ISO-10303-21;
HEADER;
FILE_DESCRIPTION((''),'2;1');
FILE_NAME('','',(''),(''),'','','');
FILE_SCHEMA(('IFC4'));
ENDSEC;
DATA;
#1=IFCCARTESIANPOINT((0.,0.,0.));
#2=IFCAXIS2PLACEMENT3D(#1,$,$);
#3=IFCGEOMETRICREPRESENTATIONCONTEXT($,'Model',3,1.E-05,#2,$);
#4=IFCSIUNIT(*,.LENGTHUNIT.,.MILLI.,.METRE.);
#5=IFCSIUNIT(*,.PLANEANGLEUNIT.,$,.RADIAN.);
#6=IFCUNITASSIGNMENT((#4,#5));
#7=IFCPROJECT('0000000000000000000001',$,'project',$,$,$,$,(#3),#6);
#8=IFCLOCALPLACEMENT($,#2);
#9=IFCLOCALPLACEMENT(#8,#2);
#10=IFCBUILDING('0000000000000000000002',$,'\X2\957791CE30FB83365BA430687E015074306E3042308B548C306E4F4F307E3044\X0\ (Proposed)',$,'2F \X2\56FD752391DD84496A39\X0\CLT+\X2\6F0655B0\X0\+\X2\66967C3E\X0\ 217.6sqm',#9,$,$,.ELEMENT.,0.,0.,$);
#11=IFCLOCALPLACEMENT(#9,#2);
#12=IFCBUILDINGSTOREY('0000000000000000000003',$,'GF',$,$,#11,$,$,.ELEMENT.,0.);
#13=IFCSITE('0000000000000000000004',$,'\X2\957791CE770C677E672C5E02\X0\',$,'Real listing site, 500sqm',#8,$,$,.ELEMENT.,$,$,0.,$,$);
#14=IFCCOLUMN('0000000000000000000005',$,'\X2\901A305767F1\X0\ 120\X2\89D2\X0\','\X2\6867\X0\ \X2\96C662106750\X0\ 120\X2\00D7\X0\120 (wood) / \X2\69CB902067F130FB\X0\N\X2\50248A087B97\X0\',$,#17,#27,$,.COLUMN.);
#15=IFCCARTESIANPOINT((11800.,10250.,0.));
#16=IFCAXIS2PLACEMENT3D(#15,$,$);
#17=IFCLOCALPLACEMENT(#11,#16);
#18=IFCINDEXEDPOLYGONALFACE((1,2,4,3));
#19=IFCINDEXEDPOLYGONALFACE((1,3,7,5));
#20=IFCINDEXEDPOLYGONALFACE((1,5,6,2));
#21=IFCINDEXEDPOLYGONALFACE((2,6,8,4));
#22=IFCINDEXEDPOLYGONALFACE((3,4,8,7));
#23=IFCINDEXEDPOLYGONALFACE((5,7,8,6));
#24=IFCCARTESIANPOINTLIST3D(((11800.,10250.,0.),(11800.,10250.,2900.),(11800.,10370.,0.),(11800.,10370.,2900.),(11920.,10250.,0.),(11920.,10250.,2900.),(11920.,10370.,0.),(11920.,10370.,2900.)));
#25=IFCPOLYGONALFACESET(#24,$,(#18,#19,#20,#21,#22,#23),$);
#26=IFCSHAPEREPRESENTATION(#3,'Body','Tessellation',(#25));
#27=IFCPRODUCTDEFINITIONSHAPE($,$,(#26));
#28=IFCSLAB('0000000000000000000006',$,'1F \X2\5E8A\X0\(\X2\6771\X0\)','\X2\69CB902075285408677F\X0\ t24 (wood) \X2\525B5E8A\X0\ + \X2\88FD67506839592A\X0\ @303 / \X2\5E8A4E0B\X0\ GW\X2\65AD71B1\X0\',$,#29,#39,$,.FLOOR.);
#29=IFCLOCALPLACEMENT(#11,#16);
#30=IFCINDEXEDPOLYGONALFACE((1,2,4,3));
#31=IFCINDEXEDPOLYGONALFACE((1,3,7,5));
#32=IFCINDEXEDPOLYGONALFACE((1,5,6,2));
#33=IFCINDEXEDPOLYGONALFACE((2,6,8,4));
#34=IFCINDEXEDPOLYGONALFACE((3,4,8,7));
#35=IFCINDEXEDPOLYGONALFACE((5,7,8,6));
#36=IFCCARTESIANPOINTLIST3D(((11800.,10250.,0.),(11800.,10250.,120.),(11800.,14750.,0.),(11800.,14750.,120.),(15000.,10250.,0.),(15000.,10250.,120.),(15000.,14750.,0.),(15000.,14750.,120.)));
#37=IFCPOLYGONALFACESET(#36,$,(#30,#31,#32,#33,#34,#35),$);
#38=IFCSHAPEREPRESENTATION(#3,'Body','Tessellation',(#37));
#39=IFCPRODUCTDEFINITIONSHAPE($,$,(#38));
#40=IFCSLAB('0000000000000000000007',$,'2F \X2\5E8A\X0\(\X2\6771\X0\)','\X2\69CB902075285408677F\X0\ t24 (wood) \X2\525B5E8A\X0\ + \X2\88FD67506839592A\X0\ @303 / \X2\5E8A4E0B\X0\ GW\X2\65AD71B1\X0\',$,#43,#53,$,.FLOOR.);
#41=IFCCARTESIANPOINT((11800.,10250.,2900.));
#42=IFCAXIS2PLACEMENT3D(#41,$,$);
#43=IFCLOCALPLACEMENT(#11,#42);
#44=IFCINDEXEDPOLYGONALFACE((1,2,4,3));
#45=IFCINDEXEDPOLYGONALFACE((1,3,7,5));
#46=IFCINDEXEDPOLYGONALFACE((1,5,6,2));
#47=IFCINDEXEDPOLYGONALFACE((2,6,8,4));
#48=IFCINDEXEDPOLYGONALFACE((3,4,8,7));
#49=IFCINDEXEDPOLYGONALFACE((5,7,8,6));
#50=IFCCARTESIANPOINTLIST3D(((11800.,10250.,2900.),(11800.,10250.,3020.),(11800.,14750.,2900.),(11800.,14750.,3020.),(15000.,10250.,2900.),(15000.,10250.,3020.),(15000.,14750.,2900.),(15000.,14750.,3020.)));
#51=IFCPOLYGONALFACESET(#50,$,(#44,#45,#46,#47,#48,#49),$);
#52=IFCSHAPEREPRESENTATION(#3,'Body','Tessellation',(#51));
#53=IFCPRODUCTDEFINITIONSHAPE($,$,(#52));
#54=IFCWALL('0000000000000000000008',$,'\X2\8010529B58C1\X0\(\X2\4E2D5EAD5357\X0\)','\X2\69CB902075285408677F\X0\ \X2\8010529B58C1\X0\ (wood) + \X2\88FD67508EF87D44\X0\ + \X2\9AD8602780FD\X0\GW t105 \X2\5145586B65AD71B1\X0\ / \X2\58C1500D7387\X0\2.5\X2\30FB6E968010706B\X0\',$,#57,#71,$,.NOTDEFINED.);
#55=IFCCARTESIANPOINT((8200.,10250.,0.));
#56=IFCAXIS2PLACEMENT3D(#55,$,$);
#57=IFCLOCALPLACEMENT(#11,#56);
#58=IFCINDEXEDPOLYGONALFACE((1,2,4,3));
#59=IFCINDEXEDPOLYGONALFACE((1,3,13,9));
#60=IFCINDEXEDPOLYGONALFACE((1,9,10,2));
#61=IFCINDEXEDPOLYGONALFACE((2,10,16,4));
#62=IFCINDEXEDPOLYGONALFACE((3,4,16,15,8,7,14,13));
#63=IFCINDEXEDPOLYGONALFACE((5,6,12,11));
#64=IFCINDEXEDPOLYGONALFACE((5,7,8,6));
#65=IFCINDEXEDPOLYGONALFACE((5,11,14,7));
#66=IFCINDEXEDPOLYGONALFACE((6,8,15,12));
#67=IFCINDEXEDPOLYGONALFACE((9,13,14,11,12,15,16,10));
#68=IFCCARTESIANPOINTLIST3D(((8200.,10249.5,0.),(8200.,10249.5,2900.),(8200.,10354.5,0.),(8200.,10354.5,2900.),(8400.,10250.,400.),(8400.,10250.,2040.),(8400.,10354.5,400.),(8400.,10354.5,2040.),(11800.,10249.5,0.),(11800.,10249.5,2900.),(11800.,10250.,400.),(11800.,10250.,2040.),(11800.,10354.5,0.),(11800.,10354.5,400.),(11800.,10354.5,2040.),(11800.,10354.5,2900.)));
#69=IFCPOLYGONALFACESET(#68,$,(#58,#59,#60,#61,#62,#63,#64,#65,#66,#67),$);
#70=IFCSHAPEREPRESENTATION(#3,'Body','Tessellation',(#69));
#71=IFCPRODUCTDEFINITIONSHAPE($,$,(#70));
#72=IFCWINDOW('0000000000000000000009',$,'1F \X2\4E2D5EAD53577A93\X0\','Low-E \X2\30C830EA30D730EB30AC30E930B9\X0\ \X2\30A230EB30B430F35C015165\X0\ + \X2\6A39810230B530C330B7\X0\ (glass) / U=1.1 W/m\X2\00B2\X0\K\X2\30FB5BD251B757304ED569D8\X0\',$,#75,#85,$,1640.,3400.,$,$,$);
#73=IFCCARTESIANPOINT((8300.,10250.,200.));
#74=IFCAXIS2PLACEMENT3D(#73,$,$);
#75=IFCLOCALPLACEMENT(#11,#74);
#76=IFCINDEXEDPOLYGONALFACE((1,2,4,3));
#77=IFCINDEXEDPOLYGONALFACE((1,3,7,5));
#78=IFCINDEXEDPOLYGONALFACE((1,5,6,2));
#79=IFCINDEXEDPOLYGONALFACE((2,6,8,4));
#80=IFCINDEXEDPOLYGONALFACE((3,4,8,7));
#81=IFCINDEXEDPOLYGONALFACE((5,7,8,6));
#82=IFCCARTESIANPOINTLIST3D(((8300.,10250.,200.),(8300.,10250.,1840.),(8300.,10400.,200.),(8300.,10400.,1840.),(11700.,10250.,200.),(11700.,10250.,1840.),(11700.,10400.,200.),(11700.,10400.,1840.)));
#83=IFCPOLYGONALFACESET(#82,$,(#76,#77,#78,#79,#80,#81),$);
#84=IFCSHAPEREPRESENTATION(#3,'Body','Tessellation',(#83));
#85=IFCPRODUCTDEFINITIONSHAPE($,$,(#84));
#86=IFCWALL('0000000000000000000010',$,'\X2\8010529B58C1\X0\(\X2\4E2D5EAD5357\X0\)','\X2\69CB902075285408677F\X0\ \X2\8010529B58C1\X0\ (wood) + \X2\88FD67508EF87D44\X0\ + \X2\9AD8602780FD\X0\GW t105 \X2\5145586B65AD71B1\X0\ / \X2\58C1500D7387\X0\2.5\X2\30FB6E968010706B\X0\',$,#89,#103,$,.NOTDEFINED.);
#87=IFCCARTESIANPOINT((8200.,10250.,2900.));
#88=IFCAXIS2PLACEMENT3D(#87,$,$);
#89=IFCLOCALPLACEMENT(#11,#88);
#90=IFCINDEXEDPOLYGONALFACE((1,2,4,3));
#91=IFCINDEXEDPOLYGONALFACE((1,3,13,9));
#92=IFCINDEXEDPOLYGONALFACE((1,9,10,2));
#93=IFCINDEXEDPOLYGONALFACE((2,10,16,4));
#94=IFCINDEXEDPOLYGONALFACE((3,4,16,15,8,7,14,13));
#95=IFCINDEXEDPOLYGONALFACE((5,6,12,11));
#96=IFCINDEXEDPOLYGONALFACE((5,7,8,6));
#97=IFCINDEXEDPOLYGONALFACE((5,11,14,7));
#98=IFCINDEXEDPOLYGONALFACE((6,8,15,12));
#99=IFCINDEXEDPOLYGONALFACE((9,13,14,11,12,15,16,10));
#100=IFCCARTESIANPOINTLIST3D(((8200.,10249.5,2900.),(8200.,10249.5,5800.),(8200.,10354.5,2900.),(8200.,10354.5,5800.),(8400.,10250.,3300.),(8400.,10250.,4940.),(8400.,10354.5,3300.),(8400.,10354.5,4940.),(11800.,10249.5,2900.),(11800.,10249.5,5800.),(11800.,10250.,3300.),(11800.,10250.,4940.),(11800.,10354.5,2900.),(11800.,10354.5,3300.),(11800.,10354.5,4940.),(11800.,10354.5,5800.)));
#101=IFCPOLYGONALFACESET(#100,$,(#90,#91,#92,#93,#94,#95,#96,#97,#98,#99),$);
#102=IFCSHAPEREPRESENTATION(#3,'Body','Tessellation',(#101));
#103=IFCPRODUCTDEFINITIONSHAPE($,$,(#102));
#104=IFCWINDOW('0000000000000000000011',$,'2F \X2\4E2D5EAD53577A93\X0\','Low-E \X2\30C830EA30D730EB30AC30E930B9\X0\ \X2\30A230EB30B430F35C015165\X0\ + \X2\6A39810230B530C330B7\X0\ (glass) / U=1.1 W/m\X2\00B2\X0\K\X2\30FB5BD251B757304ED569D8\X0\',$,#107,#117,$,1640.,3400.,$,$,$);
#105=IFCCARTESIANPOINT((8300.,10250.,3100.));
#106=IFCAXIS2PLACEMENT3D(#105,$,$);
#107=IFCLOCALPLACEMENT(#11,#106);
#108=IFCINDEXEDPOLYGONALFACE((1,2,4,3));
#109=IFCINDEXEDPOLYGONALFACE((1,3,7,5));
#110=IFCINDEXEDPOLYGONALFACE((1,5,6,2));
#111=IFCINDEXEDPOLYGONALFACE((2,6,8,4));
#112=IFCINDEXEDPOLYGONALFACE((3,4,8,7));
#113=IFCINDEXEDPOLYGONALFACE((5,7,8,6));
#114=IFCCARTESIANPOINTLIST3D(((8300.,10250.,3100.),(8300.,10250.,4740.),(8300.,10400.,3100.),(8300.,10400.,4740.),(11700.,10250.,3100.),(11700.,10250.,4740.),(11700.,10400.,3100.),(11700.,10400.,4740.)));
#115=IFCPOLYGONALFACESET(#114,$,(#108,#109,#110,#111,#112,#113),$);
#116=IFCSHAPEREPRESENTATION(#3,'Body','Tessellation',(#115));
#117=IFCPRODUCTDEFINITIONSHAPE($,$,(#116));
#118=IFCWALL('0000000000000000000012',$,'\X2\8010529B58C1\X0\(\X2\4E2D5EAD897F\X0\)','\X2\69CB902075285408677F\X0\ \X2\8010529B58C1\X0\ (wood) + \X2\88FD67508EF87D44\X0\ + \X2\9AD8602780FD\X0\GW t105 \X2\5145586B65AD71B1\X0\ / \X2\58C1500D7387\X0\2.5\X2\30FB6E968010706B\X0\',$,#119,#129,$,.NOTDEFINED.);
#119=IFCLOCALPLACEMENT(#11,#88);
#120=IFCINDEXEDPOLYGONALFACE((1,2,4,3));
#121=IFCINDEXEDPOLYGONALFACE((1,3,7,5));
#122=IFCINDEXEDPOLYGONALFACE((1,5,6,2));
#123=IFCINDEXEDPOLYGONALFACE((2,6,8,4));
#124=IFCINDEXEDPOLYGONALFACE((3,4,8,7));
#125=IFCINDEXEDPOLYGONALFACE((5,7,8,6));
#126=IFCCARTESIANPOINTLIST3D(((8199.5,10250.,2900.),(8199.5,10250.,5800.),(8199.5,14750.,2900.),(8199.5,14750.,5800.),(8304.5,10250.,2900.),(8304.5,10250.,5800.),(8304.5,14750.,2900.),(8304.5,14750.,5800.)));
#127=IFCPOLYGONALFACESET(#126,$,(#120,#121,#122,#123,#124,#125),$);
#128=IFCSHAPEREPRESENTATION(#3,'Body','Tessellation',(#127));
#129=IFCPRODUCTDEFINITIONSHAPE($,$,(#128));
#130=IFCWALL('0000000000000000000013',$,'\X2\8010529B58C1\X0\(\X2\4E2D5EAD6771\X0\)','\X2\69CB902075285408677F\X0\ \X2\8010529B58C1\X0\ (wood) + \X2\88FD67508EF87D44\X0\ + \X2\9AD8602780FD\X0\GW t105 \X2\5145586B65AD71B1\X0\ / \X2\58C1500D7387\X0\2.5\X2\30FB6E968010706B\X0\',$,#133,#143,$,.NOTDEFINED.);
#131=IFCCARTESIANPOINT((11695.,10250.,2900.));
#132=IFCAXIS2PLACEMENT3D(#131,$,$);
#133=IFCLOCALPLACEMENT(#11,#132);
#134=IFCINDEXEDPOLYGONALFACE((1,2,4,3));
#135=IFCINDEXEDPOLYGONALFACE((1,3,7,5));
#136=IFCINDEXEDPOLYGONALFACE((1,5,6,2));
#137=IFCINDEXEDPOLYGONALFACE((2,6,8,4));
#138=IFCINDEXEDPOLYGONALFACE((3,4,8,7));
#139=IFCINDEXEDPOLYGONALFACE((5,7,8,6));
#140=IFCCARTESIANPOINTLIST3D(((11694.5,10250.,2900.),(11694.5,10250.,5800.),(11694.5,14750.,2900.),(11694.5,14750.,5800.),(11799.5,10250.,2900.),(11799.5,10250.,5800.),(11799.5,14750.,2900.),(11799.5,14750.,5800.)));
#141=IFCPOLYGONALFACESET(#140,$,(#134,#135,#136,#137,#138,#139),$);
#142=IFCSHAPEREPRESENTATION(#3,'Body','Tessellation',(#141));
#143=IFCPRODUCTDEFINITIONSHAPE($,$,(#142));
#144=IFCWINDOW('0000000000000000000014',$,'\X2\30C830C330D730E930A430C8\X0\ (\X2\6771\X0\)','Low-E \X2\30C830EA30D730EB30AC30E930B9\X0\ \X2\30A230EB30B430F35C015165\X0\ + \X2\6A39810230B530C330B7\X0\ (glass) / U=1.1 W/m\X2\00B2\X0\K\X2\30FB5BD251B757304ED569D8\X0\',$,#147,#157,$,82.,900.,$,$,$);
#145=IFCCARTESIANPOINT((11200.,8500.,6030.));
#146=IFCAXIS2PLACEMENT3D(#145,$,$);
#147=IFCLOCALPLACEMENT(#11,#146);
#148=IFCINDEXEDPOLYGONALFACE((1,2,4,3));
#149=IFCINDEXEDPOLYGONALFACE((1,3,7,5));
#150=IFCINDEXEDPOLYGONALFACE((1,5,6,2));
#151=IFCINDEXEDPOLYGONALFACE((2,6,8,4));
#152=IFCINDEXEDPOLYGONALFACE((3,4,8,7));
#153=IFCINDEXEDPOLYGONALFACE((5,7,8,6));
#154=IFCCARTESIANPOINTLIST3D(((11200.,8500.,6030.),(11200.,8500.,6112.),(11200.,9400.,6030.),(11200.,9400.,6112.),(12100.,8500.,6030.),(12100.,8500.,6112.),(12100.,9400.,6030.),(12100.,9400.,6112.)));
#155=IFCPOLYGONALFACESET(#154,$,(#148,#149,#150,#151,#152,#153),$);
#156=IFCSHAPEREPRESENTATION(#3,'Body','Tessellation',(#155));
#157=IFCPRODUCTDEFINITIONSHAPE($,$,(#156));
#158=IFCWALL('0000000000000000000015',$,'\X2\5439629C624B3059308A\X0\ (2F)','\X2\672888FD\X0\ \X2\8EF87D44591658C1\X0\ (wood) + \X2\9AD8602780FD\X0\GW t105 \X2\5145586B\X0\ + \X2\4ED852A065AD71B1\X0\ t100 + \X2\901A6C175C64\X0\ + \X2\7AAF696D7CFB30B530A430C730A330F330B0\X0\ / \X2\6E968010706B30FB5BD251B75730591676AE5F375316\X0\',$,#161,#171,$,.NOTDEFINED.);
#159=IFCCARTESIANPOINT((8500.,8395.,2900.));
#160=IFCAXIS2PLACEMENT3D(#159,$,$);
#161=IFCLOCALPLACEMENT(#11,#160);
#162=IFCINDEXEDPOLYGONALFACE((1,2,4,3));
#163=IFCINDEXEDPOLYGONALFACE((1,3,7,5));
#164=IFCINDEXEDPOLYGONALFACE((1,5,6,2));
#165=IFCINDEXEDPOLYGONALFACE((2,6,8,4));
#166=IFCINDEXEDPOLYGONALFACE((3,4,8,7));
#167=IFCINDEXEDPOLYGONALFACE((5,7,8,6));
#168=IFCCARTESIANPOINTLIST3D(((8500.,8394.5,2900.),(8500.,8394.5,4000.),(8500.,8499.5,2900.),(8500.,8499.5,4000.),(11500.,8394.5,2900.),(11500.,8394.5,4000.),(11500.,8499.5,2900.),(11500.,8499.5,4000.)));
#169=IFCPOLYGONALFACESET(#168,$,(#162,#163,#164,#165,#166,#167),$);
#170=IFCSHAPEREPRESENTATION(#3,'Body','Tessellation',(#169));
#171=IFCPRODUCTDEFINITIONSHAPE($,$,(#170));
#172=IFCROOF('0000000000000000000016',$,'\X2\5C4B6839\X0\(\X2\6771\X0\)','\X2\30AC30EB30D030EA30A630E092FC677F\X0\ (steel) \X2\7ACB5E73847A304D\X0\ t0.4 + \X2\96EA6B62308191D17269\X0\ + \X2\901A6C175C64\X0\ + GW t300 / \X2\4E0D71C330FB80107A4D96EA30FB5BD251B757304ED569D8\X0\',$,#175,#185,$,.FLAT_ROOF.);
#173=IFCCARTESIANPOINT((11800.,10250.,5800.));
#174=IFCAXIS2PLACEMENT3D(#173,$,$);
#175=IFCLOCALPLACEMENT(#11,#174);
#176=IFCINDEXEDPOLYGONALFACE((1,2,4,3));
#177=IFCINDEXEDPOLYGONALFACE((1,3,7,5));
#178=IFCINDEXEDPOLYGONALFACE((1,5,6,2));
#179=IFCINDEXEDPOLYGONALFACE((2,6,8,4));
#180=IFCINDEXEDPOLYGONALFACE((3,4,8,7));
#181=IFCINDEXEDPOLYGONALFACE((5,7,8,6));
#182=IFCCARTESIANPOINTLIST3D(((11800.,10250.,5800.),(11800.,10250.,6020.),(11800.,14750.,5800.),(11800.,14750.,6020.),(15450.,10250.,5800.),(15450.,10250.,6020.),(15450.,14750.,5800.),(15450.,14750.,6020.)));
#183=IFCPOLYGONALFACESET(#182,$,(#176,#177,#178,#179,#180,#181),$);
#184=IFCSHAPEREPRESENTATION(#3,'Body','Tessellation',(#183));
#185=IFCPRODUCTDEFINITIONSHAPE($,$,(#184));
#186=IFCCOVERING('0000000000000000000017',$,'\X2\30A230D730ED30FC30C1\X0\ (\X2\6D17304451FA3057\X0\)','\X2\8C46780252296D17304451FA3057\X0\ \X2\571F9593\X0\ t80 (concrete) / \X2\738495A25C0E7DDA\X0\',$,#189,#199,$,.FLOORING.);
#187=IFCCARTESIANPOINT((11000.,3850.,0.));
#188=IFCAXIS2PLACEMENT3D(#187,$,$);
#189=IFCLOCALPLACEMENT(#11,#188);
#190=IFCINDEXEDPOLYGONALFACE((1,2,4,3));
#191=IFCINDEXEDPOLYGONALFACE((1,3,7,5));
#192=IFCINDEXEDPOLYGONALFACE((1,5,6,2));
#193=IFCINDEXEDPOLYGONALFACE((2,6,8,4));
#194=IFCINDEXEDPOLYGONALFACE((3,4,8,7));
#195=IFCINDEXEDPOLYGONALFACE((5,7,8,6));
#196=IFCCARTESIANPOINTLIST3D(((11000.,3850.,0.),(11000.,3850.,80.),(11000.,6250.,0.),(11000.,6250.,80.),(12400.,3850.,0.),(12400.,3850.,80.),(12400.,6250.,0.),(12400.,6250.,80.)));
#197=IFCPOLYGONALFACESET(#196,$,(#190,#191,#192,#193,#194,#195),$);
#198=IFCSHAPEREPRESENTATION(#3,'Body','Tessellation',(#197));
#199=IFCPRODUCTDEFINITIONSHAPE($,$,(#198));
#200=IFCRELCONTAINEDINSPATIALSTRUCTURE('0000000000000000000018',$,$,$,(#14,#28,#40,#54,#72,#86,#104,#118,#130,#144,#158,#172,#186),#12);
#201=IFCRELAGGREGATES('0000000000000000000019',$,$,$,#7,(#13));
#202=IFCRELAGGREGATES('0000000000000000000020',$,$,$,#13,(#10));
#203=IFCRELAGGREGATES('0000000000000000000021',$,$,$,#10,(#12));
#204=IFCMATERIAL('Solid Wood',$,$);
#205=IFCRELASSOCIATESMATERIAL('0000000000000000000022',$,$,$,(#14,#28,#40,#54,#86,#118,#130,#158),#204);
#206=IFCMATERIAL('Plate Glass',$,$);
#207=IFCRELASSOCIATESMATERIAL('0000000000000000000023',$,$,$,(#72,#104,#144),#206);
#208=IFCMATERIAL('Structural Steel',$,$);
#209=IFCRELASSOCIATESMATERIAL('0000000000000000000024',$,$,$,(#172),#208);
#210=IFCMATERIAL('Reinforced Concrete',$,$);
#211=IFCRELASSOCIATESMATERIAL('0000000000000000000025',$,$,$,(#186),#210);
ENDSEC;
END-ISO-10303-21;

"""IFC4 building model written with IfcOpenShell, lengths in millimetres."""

from ifc_helpers import new_model, si_unit, frame, frame_2d, origin, place, context, project, spatial, rectangle, extrude, material, element, fill, save


model = new_model("IFC4")

# Units and contexts
model_context = context("Model", 3, precision=1e-05, world=origin())
ifc_project = project(units=[si_unit("LENGTHUNIT", "METRE", prefix="MILLI"), si_unit("PLANEANGLEUNIT", "RADIAN")], contexts=[model_context])

# Site, building, storey
site_placement = place(None, origin())
site = spatial("IfcSite", under=ifc_project, at=site_placement, Name="長野県松本市", ObjectType="Real listing site, 500sqm", CompositionType="ELEMENT", RefElevation=0.0)
building_placement = place(site_placement, origin())
building = spatial("IfcBuilding", under=site, at=building_placement, Name="長野・茶室と縁側のある和の住まい (Proposed)", ObjectType="2F 国産針葉樹CLT+漆喰+暖簾 217.6sqm", CompositionType="ELEMENT", ElevationOfRefHeight=0.0, ElevationOfTerrain=0.0)
storey_placement = place(building_placement, origin())
storey = spatial("IfcBuildingStorey", under=building, at=storey_placement, Name="GF", CompositionType="ELEMENT", Elevation=0.0)

# Column
ifc_material_1 = material(Name="Solid Wood")
column_1_placement = place(storey_placement, frame((11800.0, 10250.0, 0.0)))
element("IfcColumn", 1, at=column_1_placement, inside=storey, material=ifc_material_1, Name="通し柱 120角", Description="桧 集成材 120×120 (wood) / 構造柱・N値計算", PredefinedType="COLUMN", context=model_context, shape_type="SweptSolid", body=[
    extrude(rectangle(XDim=120.0, YDim=120.0, at=frame_2d((60.0, 60.0))), frame((11800.0, 10250.0, 0.0)), (0.0, 0.0, 1.0), 2900.0),
])

# Slabs
slab_1_placement = place(storey_placement, frame((11800.0, 10250.0, 0.0)))
element("IfcSlab", 2, at=slab_1_placement, inside=storey, material=ifc_material_1, Name="1F 床(東)", Description="構造用合板 t24 (wood) 剛床 + 製材根太 @303 / 床下 GW断熱", PredefinedType="FLOOR", context=model_context, shape_type="SweptSolid", body=[
    extrude(rectangle(XDim=3200.0, YDim=4500.0, at=frame_2d((1600.0, 2250.0))), frame((11800.0, 10250.0, 0.0)), (0.0, 0.0, 1.0), 120.0),
])
slab_2_placement = place(storey_placement, frame((11800.0, 10250.0, 2900.0)))
element("IfcSlab", 3, at=slab_2_placement, inside=storey, material=ifc_material_1, Name="2F 床(東)", Description="構造用合板 t24 (wood) 剛床 + 製材根太 @303 / 床下 GW断熱", PredefinedType="FLOOR", context=model_context, shape_type="SweptSolid", body=[
    extrude(rectangle(XDim=3200.0, YDim=4500.0, at=frame_2d((1600.0, 2250.0))), frame((11800.0, 10250.0, 2900.0)), (0.0, 0.0, 1.0), 120.0),
])

# Wall, opening, window
wall_1_placement = place(storey_placement, frame((8200.0, 10250.0, 0.0)))
wall_1 = element("IfcWall", 4, at=wall_1_placement, inside=storey, material=ifc_material_1, Name="耐力壁(中庭南)", Description="構造用合板 耐力壁 (wood) + 製材軸組 + 高性能GW t105 充填断熱 / 壁倍率2.5・準耐火", PredefinedType="NOTDEFINED", context=model_context, shape_type="SweptSolid", body=[
    extrude(rectangle(XDim=3600.0, YDim=105.0, at=frame_2d((1800.0, 52.0))), frame((8200.0, 10250.0, 0.0)), (0.0, 0.0, 1.0), 2900.0),
])
opening_1_placement = place(storey_placement, frame((8300.0, 10250.0, 200.0)))
opening_1 = element("IfcOpeningElement", 5, at=opening_1_placement, cuts=wall_1, PredefinedType="NOTDEFINED", context=model_context, shape_type="SweptSolid", body=[
    extrude(rectangle(XDim=3400.0, YDim=150.0, at=frame_2d((1700.0, 75.0))), frame((8300.0, 10250.0, 200.0)), (0.0, 0.0, 1.0), 1640.0),
])
ifc_material_2 = material(Name="Plate Glass")
window_1_placement = place(storey_placement, frame((8300.0, 10250.0, 200.0)))
window_1 = element("IfcWindow", 6, at=window_1_placement, inside=storey, material=ifc_material_2, Name="1F 中庭南窓", Description="Low-E トリプルガラス アルゴン封入 + 樹脂サッシ (glass) / U=1.1 W/m²K・寒冷地仕様", OverallHeight=1640.0, OverallWidth=3400.0, context=model_context, shape_type="SweptSolid", body=[
    extrude(rectangle(XDim=3400.0, YDim=150.0, at=frame_2d((1700.0, 75.0))), frame((8300.0, 10250.0, 200.0)), (0.0, 0.0, 1.0), 1640.0),
])
fill(opening_1, window_1)

# Wall, opening, window
wall_2_placement = place(storey_placement, frame((8200.0, 10250.0, 2900.0)))
wall_2 = element("IfcWall", 7, at=wall_2_placement, inside=storey, material=ifc_material_1, Name="耐力壁(中庭南)", Description="構造用合板 耐力壁 (wood) + 製材軸組 + 高性能GW t105 充填断熱 / 壁倍率2.5・準耐火", PredefinedType="NOTDEFINED", context=model_context, shape_type="SweptSolid", body=[
    extrude(rectangle(XDim=3600.0, YDim=105.0, at=frame_2d((1800.0, 52.0))), frame((8200.0, 10250.0, 2900.0)), (0.0, 0.0, 1.0), 2900.0),
])
opening_2_placement = place(storey_placement, frame((8300.0, 10250.0, 3100.0)))
opening_2 = element("IfcOpeningElement", 8, at=opening_2_placement, cuts=wall_2, PredefinedType="NOTDEFINED", context=model_context, shape_type="SweptSolid", body=[
    extrude(rectangle(XDim=3400.0, YDim=150.0, at=frame_2d((1700.0, 75.0))), frame((8300.0, 10250.0, 3100.0)), (0.0, 0.0, 1.0), 1640.0),
])
window_2_placement = place(storey_placement, frame((8300.0, 10250.0, 3100.0)))
window_2 = element("IfcWindow", 9, at=window_2_placement, inside=storey, material=ifc_material_2, Name="2F 中庭南窓", Description="Low-E トリプルガラス アルゴン封入 + 樹脂サッシ (glass) / U=1.1 W/m²K・寒冷地仕様", OverallHeight=1640.0, OverallWidth=3400.0, context=model_context, shape_type="SweptSolid", body=[
    extrude(rectangle(XDim=3400.0, YDim=150.0, at=frame_2d((1700.0, 75.0))), frame((8300.0, 10250.0, 3100.0)), (0.0, 0.0, 1.0), 1640.0),
])
fill(opening_2, window_2)

# Walls
wall_3_placement = place(storey_placement, frame((8200.0, 10250.0, 2900.0)))
element("IfcWall", 10, at=wall_3_placement, inside=storey, material=ifc_material_1, Name="耐力壁(中庭西)", Description="構造用合板 耐力壁 (wood) + 製材軸組 + 高性能GW t105 充填断熱 / 壁倍率2.5・準耐火", PredefinedType="NOTDEFINED", context=model_context, shape_type="SweptSolid", body=[
    extrude(rectangle(XDim=105.0, YDim=4500.0, at=frame_2d((52.0, 2250.0))), frame((8200.0, 10250.0, 2900.0)), (0.0, 0.0, 1.0), 2900.0),
])
wall_4_placement = place(storey_placement, frame((11695.0, 10250.0, 2900.0)))
element("IfcWall", 11, at=wall_4_placement, inside=storey, material=ifc_material_1, Name="耐力壁(中庭東)", Description="構造用合板 耐力壁 (wood) + 製材軸組 + 高性能GW t105 充填断熱 / 壁倍率2.5・準耐火", PredefinedType="NOTDEFINED", context=model_context, shape_type="SweptSolid", body=[
    extrude(rectangle(XDim=105.0, YDim=4500.0, at=frame_2d((52.0, 2250.0))), frame((11695.0, 10250.0, 2900.0)), (0.0, 0.0, 1.0), 2900.0),
])

# Window
window_3_placement = place(storey_placement, frame((11200.0, 8500.0, 6030.0)))
element("IfcWindow", 12, at=window_3_placement, inside=storey, material=ifc_material_2, Name="トップライト (東)", Description="Low-E トリプルガラス アルゴン封入 + 樹脂サッシ (glass) / U=1.1 W/m²K・寒冷地仕様", OverallHeight=82.0, OverallWidth=900.0, context=model_context, shape_type="SweptSolid", body=[
    extrude(rectangle(XDim=900.0, YDim=900.0, at=frame_2d((450.0, 450.0))), frame((11200.0, 8500.0, 6030.0)), (0.0, 0.0, 1.0), 82.0),
])

# Wall
wall_5_placement = place(storey_placement, frame((8500.0, 8395.0, 2900.0)))
element("IfcWall", 13, at=wall_5_placement, inside=storey, material=ifc_material_1, Name="吹抜手すり (2F)", Description="木製 軸組外壁 (wood) + 高性能GW t105 充填 + 付加断熱 t100 + 通気層 + 窯業系サイディング / 準耐火・寒冷地外皮強化", PredefinedType="NOTDEFINED", context=model_context, shape_type="SweptSolid", body=[
    extrude(rectangle(XDim=3000.0, YDim=105.0, at=frame_2d((1500.0, 52.0))), frame((8500.0, 8395.0, 2900.0)), (0.0, 0.0, 1.0), 1100.0),
])

# Roof
ifc_material_3 = material(Name="Structural Steel")
for number, where, name in (
    (14, (11800.0, 10250.0, 5800.0), "屋根(東)"),
):
    element("IfcRoof", number, at=place(storey_placement, frame(where)), inside=storey, material=ifc_material_3, Name=name, Description="ガルバリウム鋼板 (steel) 立平葺き t0.4 + 雪止め金物 + 通気層 + GW t300 / 不燃・耐積雪・寒冷地仕様", PredefinedType="FLAT_ROOF", context=model_context, shape_type="SweptSolid", body=[
        extrude(rectangle(XDim=3650.0, YDim=4500.0, at=frame_2d((1825.0, 2250.0))), frame((11800.0, 10250.0, 5800.0)), (0.0, 0.0, 1.0), 220.0),
    ])

# Covering
ifc_material_4 = material(Name="Reinforced Concrete")
covering_placement = place(storey_placement, frame((11000.0, 3850.0, 0.0)))
element("IfcCovering", 15, at=covering_placement, inside=storey, material=ifc_material_4, Name="アプローチ (洗い出し)", Description="豆砂利洗い出し 土間 t80 (concrete) / 玄関導線", PredefinedType="FLOORING", context=model_context, shape_type="SweptSolid", body=[
    extrude(rectangle(XDim=1400.0, YDim=2400.0, at=frame_2d((700.0, 1200.0))), frame((11000.0, 3850.0, 0.0)), (0.0, 0.0, 1.0), 80.0),
])

save(model, "model.ifc")
